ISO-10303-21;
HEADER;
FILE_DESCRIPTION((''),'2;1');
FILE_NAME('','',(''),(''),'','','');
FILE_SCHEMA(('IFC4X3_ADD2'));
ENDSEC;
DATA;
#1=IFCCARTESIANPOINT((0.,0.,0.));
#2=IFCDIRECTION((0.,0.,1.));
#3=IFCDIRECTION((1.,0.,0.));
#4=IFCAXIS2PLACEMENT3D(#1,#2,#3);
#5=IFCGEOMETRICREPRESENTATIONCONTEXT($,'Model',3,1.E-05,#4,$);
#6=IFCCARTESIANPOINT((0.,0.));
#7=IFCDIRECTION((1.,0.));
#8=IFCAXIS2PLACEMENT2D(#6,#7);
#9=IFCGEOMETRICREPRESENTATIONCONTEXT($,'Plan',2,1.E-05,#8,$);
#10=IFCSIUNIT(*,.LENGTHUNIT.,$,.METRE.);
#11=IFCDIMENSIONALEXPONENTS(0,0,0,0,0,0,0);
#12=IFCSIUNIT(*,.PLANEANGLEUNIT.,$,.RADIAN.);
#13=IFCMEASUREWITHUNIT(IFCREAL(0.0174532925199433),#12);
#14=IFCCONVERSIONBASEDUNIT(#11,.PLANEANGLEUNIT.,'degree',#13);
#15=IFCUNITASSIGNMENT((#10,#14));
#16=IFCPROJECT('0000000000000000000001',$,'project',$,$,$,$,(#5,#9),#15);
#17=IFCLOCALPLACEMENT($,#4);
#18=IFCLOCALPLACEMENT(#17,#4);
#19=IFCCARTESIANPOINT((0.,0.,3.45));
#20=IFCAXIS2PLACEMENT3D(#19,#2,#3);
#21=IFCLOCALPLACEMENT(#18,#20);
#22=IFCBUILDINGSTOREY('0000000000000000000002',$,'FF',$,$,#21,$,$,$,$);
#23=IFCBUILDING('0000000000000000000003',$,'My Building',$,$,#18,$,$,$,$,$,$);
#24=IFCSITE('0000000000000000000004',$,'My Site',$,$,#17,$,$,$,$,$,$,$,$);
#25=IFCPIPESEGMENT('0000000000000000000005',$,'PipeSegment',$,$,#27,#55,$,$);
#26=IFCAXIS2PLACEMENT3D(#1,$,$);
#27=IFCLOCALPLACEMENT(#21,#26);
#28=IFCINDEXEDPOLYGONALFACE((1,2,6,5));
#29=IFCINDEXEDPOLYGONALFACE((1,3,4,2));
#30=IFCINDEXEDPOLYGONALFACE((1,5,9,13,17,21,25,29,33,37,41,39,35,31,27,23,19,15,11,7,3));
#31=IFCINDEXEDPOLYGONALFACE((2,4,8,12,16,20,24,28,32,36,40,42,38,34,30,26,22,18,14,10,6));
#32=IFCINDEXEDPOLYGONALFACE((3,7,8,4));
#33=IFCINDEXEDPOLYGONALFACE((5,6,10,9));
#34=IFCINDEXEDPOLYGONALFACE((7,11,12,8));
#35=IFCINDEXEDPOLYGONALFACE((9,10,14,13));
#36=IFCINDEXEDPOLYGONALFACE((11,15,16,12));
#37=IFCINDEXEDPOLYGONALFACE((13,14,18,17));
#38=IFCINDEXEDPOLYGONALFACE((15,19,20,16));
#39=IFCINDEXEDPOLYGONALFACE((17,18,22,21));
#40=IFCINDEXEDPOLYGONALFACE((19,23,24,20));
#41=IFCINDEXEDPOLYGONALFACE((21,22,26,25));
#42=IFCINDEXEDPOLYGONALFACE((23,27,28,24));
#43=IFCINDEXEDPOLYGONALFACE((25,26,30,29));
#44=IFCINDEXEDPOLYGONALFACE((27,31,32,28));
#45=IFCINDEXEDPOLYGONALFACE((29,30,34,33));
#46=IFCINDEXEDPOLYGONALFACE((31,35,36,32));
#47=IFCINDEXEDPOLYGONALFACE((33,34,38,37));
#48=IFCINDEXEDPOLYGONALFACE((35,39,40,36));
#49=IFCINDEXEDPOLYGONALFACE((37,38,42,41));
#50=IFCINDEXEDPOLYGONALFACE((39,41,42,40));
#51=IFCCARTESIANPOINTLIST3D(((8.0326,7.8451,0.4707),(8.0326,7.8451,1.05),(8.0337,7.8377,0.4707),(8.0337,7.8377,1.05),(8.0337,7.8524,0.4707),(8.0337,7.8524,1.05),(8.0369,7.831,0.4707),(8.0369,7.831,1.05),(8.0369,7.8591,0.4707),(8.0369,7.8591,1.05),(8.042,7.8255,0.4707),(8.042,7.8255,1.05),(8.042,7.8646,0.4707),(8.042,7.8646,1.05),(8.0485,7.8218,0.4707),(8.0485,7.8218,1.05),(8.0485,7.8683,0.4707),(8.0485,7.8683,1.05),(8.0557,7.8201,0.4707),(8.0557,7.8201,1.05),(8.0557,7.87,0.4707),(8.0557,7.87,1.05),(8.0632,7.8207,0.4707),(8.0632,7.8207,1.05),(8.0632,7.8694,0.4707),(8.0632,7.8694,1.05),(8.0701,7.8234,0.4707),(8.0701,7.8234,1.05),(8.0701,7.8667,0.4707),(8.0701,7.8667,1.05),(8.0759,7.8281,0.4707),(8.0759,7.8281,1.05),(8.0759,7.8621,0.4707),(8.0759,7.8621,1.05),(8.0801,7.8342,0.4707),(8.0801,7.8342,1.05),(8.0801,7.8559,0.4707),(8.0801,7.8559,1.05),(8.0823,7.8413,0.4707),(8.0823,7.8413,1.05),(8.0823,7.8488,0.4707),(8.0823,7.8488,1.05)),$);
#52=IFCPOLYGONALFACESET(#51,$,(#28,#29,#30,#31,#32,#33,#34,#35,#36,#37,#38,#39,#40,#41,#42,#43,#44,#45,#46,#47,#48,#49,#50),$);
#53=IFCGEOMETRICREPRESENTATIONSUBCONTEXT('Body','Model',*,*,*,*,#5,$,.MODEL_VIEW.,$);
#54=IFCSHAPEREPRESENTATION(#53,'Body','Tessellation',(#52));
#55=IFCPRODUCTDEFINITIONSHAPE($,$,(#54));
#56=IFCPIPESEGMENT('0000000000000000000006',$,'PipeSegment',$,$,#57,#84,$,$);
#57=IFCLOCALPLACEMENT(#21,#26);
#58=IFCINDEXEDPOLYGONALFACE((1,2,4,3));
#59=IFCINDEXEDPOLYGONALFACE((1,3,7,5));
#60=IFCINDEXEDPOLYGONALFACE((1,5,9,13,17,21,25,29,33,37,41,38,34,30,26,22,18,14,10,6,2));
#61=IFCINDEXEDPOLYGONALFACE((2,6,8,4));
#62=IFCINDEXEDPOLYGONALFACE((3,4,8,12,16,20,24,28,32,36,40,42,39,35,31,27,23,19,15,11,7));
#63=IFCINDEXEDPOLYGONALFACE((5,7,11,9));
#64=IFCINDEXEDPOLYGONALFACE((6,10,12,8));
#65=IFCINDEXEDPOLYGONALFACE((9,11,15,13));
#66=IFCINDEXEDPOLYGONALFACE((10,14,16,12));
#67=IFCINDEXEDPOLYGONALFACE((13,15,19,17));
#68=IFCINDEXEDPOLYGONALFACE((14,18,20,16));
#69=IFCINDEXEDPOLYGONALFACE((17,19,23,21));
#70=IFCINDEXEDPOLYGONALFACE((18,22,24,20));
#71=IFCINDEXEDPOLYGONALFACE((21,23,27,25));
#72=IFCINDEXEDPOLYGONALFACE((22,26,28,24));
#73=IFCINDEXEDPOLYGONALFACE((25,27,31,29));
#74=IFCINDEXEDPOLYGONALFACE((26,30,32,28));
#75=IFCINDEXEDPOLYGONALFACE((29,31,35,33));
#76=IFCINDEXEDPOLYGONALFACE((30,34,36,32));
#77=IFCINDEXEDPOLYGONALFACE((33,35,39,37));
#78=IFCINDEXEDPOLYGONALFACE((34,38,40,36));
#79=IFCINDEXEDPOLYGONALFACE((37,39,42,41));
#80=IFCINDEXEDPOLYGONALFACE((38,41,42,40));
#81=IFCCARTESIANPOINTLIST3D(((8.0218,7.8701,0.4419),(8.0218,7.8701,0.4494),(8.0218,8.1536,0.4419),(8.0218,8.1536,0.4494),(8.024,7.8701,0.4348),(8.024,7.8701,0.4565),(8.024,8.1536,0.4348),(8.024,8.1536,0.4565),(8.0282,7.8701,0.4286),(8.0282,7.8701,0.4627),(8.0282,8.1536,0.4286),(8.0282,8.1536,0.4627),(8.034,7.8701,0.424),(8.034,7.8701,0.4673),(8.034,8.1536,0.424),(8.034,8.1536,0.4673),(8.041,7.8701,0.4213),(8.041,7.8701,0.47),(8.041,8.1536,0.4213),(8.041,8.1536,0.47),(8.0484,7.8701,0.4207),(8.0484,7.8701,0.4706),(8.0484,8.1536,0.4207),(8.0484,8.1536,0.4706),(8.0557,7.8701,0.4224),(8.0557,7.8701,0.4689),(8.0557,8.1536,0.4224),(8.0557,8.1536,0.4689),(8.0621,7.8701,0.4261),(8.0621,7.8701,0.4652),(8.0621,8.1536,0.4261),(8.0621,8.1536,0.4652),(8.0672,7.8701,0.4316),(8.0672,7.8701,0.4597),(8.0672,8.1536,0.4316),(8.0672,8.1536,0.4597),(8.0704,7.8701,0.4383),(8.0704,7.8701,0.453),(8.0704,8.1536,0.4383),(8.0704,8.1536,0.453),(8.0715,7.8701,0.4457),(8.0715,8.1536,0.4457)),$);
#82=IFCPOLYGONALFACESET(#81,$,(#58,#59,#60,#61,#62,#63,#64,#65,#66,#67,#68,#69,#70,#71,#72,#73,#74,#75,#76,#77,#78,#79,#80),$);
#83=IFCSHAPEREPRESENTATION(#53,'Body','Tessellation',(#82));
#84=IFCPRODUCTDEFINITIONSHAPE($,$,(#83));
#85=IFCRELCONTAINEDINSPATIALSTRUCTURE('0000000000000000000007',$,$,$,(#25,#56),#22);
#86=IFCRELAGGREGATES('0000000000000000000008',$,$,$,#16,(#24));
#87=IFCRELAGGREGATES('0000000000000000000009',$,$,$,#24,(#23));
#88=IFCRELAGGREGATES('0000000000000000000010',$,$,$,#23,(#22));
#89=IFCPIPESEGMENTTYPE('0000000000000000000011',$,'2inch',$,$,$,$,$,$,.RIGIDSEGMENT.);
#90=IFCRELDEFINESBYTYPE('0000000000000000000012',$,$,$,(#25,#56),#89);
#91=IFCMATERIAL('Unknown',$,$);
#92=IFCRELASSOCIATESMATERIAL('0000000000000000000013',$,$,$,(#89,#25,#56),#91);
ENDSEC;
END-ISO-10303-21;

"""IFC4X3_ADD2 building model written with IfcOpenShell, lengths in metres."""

from ifc_helpers import new_model, entity, si_unit, converted_unit, frame, origin_with_axes, origin_2d_with_axis, place, context, subcontext, project, spatial, circle, extrude, material, material_profile, profile_set, profile_usage, type_object, element, save


model = new_model("IFC4X3_ADD2")

# Units and contexts
model_context = context("Model", 3, precision=1e-05, world=origin_with_axes())
plan_context = context("Plan", 2, precision=1e-05, world=origin_2d_with_axis())
body_context_1 = subcontext(model_context, "Body", "Model", "MODEL_VIEW")
ifc_project = project(units=[si_unit("LENGTHUNIT", "METRE"), converted_unit("PLANEANGLEUNIT", "degree", entity("IfcReal", 0.0174532925199433), si_unit("PLANEANGLEUNIT", "RADIAN"), dimensions=[0, 0, 0, 0, 0, 0, 0])], contexts=[model_context, plan_context])

# Site, building, storey
site_placement = place(None, origin_with_axes())
site = spatial("IfcSite", under=ifc_project, at=site_placement, Name="My Site")
building_placement = place(site_placement, origin_with_axes())
building = spatial("IfcBuilding", under=site, at=building_placement, Name="My Building")
storey_placement = place(building_placement, frame((0.0, 0.0, 3.45), z_axis=(0.0, 0.0, 1.0), x_axis=(1.0, 0.0, 0.0)))
storey = spatial("IfcBuildingStorey", under=building, at=storey_placement, Name="FF")

# Shared definitions
ifc_material = material(Name="Unknown")

# Pipe segments
ifc_material_profile = material_profile(ifc_material, circle(Radius=0.025))
ifc_profile_set = profile_set([ifc_material_profile])
pipe_segment_type = type_object("IfcPipeSegmentType", Name="2inch", PredefinedType="RIGIDSEGMENT", material=ifc_profile_set)
ifc_profile_usage_1 = profile_usage(ifc_profile_set)
pipe_segment_1_placement = place(storey_placement, frame((8.0576, 7.8451, 0.4707), z_axis=(0.0, 0.0, 1.0), x_axis=(-1.0, 0.0, 0.0)))
element("IfcPipeSegment", 1, at=pipe_segment_1_placement, inside=storey, type_object=pipe_segment_type, material=ifc_profile_usage_1, Name="PipeSegment", context=body_context_1, shape_type="SweptSolid", body=[
    extrude(circle(Radius=0.025), origin_with_axes(), (0.0, 0.0, 1.0), 0.5793),
])
ifc_profile_usage_2 = profile_usage(ifc_profile_set)
pipe_segment_2_placement = place(storey_placement, frame((8.0465, 8.1536, 0.4457), z_axis=(0.0, -1.0, 0.0), x_axis=(1.0, 0.0, 0.0)))
element("IfcPipeSegment", 2, at=pipe_segment_2_placement, inside=storey, type_object=pipe_segment_type, material=ifc_profile_usage_2, Name="PipeSegment", context=body_context_1, shape_type="SweptSolid", body=[
    extrude(circle(Radius=0.025), origin_with_axes(), (0.0, 0.0, 1.0), 0.2835),
])

save(model, "model.ifc")
